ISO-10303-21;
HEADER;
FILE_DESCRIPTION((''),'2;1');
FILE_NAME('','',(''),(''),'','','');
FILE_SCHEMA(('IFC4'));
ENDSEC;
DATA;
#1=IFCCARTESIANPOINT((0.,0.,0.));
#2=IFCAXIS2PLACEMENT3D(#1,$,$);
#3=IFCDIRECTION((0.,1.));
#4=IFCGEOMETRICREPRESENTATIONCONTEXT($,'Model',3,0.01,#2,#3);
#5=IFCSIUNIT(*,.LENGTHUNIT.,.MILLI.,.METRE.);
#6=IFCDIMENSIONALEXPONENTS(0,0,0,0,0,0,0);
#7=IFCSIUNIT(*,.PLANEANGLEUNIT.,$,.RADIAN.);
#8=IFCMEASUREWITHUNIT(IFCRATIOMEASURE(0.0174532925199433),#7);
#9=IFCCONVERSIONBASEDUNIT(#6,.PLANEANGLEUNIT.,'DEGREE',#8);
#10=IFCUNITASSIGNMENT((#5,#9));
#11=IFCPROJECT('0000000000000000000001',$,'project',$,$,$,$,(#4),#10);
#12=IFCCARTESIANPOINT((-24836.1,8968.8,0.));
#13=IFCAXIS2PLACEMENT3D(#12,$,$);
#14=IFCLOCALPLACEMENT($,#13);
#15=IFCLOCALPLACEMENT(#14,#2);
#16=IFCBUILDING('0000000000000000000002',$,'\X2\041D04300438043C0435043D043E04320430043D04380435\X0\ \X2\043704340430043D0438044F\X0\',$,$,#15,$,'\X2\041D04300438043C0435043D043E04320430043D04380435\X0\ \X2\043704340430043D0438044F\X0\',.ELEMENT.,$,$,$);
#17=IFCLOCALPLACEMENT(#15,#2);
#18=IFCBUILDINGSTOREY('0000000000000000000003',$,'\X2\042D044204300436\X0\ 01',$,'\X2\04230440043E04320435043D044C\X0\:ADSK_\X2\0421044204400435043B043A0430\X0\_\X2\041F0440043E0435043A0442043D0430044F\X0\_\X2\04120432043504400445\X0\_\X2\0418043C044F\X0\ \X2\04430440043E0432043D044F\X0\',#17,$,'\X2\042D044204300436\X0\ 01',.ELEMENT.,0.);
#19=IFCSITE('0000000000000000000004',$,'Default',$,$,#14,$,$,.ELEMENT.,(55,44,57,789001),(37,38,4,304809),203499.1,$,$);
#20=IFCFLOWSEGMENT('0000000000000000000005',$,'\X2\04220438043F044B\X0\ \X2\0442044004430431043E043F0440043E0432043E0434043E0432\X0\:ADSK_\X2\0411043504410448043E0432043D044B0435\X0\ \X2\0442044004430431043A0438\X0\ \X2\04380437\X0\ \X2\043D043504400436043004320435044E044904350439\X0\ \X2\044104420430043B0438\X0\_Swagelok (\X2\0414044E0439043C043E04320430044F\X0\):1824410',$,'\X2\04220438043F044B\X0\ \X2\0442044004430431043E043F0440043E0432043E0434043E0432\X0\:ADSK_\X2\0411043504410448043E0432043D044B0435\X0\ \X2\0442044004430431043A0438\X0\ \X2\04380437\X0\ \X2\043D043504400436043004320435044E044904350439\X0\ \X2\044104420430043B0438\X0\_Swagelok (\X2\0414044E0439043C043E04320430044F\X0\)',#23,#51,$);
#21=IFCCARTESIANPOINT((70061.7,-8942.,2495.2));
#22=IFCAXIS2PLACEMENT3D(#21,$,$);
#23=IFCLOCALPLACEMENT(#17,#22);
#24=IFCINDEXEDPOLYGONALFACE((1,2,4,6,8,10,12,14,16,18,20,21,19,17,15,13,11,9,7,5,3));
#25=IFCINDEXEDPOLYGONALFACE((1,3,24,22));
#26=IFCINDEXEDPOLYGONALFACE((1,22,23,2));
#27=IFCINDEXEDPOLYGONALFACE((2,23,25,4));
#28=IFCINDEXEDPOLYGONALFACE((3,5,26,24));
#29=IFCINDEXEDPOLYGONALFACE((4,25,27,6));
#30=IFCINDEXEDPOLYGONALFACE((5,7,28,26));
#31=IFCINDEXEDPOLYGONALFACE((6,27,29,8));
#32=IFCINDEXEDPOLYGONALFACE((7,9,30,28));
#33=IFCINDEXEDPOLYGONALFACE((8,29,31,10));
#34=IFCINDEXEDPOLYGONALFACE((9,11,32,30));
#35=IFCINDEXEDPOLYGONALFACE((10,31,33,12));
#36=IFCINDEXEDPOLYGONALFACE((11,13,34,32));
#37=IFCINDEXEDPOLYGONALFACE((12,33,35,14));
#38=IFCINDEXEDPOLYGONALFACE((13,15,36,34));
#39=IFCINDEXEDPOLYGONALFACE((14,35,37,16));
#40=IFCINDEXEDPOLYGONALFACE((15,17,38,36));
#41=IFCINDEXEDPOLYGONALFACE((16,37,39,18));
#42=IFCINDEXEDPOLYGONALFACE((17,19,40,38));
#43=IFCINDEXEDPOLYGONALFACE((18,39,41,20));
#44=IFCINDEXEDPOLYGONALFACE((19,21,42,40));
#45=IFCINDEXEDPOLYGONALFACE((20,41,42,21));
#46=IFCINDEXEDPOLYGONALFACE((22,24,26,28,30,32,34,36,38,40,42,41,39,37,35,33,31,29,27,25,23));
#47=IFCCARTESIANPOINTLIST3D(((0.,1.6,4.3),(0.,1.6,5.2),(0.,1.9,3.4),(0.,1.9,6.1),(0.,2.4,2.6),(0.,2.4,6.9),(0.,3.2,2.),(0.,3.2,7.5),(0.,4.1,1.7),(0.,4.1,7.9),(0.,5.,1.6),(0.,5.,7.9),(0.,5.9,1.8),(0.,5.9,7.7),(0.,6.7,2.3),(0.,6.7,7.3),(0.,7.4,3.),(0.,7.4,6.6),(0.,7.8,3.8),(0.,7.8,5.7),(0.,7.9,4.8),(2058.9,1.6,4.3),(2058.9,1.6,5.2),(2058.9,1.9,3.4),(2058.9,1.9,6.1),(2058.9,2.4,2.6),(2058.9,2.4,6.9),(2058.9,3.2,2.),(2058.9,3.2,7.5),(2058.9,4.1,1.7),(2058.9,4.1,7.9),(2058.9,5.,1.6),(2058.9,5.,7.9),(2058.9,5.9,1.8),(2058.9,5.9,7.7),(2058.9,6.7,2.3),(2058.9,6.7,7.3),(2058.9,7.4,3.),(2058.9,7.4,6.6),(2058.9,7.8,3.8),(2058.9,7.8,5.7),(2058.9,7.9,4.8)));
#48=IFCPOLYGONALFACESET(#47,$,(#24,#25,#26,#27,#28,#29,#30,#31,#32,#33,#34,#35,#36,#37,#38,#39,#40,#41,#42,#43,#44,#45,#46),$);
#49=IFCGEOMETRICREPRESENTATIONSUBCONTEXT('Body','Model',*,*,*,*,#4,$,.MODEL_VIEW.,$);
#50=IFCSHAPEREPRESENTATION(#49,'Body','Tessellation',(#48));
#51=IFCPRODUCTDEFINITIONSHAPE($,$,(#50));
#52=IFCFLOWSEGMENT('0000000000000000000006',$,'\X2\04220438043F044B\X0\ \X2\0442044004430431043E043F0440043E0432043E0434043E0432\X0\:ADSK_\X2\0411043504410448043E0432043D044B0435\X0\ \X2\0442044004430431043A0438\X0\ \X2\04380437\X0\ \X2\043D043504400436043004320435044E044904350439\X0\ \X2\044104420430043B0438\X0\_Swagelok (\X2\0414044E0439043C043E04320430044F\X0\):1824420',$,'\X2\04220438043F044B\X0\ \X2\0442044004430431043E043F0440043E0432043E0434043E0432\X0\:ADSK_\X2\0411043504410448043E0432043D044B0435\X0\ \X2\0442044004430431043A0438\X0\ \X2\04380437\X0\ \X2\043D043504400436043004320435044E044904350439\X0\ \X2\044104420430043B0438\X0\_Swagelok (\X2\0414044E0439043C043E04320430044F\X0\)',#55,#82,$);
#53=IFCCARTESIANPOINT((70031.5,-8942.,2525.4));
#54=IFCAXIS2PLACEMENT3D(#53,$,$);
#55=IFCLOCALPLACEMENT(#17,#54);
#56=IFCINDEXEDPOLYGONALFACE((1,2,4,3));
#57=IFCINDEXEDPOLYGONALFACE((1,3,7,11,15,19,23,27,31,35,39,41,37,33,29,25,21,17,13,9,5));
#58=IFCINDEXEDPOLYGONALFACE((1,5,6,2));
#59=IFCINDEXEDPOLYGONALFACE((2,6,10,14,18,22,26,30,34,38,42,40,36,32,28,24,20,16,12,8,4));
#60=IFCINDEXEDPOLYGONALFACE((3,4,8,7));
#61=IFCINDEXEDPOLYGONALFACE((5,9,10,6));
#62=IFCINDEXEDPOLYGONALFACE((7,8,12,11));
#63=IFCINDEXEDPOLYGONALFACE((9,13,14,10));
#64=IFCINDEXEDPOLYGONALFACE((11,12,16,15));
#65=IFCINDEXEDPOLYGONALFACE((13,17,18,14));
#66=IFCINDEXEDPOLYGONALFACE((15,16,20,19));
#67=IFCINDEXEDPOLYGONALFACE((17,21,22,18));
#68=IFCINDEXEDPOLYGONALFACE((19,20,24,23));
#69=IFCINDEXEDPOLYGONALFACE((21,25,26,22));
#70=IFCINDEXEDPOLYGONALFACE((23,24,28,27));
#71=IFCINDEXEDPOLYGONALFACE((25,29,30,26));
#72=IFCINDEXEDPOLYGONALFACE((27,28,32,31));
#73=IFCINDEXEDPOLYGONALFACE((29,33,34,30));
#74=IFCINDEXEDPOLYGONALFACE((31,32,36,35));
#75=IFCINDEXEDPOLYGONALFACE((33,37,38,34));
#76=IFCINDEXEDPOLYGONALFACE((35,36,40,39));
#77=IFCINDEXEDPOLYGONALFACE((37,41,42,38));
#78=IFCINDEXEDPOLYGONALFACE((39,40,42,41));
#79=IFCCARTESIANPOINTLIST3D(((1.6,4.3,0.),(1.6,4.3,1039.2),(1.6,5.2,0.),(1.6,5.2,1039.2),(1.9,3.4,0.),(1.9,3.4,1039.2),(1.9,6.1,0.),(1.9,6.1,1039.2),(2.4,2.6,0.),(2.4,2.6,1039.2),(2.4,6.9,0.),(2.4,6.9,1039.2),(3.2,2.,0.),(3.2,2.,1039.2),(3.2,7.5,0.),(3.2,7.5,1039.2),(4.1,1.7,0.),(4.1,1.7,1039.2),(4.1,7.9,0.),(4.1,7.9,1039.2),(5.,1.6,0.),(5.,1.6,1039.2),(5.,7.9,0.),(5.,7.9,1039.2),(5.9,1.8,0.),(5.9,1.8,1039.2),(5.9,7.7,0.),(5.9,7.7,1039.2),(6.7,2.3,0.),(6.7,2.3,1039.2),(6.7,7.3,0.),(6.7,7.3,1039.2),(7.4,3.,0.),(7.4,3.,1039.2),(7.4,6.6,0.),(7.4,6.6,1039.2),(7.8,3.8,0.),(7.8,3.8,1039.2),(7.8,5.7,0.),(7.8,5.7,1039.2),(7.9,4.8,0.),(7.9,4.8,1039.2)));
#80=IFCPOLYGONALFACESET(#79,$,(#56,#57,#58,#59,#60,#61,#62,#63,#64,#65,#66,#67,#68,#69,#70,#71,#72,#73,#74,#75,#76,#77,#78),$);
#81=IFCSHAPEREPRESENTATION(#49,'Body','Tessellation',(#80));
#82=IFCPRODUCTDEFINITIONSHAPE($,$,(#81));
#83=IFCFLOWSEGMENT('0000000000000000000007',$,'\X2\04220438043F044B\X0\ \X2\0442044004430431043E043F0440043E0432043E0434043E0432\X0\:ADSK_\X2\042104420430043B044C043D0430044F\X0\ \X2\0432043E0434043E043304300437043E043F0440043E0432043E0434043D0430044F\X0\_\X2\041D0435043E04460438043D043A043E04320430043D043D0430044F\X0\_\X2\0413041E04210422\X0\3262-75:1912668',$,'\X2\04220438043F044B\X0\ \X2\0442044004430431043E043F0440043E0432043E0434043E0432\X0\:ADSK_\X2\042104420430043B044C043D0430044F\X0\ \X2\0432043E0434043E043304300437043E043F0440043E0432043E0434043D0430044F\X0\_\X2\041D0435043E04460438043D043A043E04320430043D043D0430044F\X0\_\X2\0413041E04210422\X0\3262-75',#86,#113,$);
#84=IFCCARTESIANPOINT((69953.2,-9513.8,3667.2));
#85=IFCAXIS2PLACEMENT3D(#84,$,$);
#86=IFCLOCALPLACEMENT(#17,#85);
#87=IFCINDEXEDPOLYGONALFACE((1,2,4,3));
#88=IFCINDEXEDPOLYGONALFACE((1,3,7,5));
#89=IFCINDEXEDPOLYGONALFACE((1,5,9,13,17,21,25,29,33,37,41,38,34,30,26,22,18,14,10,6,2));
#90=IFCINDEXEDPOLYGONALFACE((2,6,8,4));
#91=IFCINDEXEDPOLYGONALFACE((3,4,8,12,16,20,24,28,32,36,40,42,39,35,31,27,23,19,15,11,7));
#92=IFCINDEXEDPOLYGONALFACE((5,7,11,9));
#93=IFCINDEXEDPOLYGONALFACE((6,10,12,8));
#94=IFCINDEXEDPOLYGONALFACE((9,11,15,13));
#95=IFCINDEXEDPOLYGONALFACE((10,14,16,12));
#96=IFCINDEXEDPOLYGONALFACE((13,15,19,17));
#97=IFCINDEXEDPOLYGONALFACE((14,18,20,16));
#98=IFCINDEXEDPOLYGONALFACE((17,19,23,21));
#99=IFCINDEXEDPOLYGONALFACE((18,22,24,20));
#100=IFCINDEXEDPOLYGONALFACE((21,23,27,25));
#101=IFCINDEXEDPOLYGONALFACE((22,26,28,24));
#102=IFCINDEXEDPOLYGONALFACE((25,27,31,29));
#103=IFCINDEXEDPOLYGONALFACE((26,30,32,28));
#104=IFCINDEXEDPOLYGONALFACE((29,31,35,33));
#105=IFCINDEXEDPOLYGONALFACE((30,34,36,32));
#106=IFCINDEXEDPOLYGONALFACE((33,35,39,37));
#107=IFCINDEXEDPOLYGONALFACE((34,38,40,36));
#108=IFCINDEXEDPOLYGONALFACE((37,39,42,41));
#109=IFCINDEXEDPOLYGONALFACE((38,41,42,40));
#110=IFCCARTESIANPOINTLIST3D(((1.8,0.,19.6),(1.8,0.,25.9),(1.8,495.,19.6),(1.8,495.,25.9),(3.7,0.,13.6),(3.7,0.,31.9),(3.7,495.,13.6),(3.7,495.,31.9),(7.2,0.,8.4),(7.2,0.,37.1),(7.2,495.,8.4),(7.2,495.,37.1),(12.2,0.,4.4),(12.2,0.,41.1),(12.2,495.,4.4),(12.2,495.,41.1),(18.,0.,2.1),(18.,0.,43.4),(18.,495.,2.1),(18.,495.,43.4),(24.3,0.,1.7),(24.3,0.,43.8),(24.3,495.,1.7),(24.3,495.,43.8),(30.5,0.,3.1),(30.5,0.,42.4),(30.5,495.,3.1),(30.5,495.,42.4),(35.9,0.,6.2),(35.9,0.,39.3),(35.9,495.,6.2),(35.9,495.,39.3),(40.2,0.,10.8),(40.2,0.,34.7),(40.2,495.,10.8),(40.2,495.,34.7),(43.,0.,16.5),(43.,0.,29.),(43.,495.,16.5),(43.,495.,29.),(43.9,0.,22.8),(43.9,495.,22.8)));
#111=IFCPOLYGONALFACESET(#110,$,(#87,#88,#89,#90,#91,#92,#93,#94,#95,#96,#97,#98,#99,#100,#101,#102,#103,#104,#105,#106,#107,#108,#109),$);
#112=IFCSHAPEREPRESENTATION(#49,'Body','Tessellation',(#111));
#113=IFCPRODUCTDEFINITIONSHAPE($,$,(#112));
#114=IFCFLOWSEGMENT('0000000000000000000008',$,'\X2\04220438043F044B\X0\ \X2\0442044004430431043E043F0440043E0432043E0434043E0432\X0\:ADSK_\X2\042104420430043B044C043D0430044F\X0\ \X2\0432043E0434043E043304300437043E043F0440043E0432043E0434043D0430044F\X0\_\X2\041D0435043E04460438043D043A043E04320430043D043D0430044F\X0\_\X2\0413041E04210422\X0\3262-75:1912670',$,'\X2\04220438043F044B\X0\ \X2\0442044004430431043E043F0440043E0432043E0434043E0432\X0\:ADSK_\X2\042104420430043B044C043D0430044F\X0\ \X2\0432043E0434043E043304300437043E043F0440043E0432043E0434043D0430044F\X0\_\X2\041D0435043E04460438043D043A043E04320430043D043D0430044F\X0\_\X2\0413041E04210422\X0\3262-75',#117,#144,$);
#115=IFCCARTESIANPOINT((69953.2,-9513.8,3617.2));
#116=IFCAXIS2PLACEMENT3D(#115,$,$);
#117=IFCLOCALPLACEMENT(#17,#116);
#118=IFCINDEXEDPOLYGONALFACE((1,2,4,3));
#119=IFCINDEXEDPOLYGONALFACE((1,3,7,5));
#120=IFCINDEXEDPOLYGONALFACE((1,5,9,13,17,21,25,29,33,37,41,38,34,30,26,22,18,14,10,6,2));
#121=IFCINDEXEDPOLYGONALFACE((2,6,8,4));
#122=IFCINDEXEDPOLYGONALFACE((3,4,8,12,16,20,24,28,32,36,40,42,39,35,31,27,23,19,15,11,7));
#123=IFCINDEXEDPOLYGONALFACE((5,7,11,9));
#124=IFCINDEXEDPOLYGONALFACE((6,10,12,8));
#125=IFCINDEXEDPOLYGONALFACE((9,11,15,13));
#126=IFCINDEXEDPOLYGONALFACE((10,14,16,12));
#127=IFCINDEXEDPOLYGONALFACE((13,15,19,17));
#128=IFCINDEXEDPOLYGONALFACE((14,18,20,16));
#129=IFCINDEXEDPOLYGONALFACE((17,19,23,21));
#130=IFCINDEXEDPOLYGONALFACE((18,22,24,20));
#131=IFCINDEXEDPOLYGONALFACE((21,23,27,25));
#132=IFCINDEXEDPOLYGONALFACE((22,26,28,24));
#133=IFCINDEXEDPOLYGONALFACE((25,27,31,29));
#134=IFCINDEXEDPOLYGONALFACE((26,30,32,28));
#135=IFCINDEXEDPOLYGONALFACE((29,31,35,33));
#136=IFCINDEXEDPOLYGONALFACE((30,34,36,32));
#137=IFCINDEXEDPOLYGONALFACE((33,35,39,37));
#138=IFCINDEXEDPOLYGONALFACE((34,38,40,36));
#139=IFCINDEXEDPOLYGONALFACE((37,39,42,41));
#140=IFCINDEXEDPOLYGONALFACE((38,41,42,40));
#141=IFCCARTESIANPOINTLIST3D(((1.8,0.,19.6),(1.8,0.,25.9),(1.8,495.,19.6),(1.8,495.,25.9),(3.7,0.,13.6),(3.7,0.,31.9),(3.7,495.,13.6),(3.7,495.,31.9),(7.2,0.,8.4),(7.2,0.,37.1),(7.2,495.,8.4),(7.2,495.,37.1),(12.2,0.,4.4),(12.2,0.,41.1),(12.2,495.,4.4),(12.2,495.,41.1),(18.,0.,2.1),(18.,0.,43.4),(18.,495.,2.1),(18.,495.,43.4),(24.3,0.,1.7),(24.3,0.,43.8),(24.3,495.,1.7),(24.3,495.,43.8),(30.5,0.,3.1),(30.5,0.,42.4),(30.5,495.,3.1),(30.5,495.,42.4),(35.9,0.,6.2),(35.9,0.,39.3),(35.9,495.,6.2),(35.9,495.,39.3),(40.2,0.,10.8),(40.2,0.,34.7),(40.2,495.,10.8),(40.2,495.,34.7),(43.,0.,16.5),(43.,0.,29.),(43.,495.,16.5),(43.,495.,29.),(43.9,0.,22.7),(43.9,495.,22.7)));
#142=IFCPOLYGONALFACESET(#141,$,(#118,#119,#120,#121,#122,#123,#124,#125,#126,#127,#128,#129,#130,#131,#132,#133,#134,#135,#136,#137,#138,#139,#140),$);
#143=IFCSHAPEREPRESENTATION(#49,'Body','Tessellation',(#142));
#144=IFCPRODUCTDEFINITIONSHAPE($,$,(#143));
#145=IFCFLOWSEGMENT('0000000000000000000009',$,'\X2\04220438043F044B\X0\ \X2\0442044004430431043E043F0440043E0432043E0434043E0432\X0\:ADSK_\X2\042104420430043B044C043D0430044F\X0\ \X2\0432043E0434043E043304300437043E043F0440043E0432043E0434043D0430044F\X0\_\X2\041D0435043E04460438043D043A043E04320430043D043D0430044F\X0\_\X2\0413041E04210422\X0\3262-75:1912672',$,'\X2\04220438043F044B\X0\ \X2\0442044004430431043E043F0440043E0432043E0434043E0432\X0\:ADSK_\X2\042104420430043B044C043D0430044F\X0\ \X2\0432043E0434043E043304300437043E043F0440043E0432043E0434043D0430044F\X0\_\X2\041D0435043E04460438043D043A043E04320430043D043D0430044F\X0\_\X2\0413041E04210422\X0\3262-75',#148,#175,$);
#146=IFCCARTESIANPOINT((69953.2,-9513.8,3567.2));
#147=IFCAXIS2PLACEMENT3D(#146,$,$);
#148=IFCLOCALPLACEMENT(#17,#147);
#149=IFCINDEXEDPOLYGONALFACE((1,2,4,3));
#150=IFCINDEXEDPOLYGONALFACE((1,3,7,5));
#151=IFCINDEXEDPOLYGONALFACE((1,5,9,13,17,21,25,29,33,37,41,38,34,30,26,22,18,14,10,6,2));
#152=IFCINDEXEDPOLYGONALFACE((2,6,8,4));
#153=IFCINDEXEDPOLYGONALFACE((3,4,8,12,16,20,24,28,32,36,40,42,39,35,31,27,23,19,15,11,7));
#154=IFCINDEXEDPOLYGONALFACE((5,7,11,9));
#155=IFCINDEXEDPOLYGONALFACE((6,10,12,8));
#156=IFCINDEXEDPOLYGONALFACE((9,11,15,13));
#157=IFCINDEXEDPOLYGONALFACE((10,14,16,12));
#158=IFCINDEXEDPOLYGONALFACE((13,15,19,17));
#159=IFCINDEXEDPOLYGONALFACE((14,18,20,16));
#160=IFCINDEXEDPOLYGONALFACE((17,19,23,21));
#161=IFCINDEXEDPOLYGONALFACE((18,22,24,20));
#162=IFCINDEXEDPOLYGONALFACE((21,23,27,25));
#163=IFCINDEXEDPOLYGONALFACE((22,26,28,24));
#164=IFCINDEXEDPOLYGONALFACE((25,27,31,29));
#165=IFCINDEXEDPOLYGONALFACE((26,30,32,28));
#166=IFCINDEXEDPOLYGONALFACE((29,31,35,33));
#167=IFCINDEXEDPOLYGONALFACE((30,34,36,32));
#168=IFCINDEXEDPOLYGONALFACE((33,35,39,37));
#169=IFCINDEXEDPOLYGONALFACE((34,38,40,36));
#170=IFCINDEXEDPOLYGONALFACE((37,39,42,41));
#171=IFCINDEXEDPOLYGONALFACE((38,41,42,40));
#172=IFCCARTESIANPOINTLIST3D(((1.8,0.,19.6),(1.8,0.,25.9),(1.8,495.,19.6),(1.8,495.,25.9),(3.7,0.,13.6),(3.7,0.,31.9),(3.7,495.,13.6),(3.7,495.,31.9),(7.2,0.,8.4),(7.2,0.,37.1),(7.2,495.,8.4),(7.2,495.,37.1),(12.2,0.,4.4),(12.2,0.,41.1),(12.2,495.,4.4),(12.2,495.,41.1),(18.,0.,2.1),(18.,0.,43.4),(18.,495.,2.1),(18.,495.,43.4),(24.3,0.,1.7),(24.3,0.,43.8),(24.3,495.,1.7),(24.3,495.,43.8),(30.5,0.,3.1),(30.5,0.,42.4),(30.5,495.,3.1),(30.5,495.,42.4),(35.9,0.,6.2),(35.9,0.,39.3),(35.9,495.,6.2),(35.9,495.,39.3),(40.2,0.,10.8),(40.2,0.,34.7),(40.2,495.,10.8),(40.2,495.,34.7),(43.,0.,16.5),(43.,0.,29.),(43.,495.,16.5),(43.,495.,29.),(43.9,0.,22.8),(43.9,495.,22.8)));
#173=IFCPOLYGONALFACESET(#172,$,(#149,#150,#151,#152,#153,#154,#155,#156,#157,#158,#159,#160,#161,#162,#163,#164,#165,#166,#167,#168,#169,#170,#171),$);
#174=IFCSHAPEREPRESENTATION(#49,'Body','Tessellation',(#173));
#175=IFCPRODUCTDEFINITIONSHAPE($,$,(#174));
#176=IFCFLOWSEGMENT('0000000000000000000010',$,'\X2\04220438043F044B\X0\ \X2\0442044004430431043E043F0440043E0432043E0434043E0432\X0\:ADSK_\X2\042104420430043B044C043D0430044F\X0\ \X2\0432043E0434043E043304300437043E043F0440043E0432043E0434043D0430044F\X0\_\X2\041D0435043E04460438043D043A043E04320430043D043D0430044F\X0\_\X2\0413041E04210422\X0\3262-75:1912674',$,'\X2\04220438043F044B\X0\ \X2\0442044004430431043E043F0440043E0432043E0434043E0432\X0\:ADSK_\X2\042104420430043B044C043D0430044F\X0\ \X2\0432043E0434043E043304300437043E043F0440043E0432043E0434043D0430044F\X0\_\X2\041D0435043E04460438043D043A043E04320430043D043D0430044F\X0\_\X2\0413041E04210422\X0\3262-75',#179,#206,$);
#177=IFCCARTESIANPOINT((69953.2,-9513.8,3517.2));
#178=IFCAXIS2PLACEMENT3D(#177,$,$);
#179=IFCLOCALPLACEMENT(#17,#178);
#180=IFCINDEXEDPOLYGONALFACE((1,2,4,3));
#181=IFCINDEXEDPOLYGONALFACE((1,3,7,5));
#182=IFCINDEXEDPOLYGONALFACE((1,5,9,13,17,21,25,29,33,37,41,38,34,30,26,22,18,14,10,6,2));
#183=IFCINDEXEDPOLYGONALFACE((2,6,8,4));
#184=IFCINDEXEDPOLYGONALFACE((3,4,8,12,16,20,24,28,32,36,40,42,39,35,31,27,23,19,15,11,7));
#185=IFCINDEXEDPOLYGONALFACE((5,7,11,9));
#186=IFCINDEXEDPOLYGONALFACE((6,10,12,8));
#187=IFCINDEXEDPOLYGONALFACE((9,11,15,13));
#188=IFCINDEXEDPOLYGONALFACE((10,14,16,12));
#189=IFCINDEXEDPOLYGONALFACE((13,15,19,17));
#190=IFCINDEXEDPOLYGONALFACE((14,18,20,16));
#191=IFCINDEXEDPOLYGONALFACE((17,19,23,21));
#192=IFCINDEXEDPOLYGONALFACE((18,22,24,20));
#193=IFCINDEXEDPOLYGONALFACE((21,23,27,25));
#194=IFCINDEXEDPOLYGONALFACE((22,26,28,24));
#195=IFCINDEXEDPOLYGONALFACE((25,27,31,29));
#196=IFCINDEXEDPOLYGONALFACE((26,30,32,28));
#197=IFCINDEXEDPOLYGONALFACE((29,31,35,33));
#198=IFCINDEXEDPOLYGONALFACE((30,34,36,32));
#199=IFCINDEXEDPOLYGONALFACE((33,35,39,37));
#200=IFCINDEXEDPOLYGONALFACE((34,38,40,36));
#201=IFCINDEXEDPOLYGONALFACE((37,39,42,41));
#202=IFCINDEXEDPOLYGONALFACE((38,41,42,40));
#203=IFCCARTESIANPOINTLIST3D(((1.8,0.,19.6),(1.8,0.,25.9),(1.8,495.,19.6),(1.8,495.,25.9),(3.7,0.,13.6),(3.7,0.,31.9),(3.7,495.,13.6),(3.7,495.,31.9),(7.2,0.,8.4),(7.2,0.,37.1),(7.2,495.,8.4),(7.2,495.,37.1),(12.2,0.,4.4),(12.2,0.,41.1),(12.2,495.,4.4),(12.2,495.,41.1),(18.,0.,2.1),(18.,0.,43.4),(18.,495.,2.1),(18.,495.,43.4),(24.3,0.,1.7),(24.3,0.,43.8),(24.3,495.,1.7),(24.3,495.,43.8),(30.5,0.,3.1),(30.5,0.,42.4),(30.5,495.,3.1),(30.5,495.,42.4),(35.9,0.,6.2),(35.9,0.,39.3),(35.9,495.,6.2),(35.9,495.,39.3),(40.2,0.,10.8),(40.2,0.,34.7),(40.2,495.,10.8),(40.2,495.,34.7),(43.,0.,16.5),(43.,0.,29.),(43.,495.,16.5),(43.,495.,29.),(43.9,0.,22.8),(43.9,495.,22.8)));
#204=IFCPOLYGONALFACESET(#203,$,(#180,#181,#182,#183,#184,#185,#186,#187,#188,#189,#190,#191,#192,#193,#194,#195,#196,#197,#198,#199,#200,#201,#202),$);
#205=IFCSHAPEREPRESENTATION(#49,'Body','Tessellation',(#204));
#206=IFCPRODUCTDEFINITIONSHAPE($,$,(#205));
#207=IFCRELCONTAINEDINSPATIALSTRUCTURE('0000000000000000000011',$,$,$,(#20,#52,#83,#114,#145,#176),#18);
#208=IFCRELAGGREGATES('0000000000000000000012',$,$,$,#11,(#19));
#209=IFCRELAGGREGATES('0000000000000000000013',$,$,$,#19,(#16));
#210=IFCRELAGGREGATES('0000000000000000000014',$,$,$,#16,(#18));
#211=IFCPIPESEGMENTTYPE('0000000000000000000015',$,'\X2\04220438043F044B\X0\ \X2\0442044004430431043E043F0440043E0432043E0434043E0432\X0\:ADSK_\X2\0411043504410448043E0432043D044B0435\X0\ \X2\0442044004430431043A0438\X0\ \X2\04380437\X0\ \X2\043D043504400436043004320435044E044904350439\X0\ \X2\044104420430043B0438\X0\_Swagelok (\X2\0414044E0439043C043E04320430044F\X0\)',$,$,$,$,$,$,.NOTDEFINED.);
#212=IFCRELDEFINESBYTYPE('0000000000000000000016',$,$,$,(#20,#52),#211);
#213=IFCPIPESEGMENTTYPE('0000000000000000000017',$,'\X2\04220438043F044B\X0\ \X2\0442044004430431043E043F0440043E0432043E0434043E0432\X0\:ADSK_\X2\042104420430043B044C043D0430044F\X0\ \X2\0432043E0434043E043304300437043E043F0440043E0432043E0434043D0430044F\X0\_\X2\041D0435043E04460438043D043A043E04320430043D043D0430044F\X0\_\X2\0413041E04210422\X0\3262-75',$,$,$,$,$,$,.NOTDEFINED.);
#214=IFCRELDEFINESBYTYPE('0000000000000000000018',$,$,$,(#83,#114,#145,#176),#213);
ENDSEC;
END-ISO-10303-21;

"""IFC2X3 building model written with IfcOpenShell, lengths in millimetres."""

from ifc_helpers import new_model, entity, si_unit, converted_unit, direction, frame, origin, origin_2d_with_axis, place, context, subcontext, project, spatial, circle, extrude, type_object, element, save


model = new_model("IFC2X3")

# Units and contexts
model_context = context("Model", 3, precision=0.01, world=origin(), true_north=direction((0.0, 1.0)))
body_context = subcontext(model_context, "Body", "Model", "MODEL_VIEW")
ifc_project = project(units=[si_unit("LENGTHUNIT", "METRE", prefix="MILLI"), converted_unit("PLANEANGLEUNIT", "DEGREE", entity("IfcRatioMeasure", 0.0174532925199433), si_unit("PLANEANGLEUNIT", "RADIAN"), dimensions=[0, 0, 0, 0, 0, 0, 0])], contexts=[model_context])

# Site, building, storey
site_placement = place(None, frame((-24836.1, 8968.8, 0.0)))
site = spatial("IfcSite", under=ifc_project, at=site_placement, Name="Default", CompositionType="ELEMENT", RefLatitude=(55, 44, 57, 789001), RefLongitude=(37, 38, 4, 304809), RefElevation=203499.1)
building_placement = place(site_placement, origin())
building = spatial("IfcBuilding", under=site, at=building_placement, Name="Наименование здания", LongName="Наименование здания", CompositionType="ELEMENT")
storey_placement = place(building_placement, origin())
storey = spatial("IfcBuildingStorey", under=building, at=storey_placement, Name="Этаж 01", ObjectType="Уровень:ADSK_Стрелка_Проектная_Вверх_Имя уровня", LongName="Этаж 01", CompositionType="ELEMENT", Elevation=0.0)

# Flow segments
pipe_segment_type_1 = type_object("IfcPipeSegmentType", Name="Типы трубопроводов:ADSK_Бесшовные трубки из нержавеющей стали_Swagelok (Дюймовая)", PredefinedType="NOTDEFINED")
flow_segment_1_placement = place(storey_placement, frame((70061.7, -8942.0, 2495.2)))
element("IfcFlowSegment", 1, at=flow_segment_1_placement, inside=storey, type_object=pipe_segment_type_1, Name="Типы трубопроводов:ADSK_Бесшовные трубки из нержавеющей стали_Swagelok (Дюймовая):1824410", ObjectType="Типы трубопроводов:ADSK_Бесшовные трубки из нержавеющей стали_Swagelok (Дюймовая)", context=body_context, shape_type="SweptSolid", body=[
    extrude(circle(Radius=3.2, at=origin_2d_with_axis()), frame((0.0, 4.8, 4.8), z_axis=(1.0, 0.0, 0.0), x_axis=(0.0, 1.0, 0.0)), (0.0, 0.0, 1.0), 2058.9),
])
flow_segment_2_placement = place(storey_placement, frame((70031.5, -8942.0, 2525.4)))
element("IfcFlowSegment", 2, at=flow_segment_2_placement, inside=storey, type_object=pipe_segment_type_1, Name="Типы трубопроводов:ADSK_Бесшовные трубки из нержавеющей стали_Swagelok (Дюймовая):1824420", ObjectType="Типы трубопроводов:ADSK_Бесшовные трубки из нержавеющей стали_Swagelok (Дюймовая)", context=body_context, shape_type="SweptSolid", body=[
    extrude(circle(Radius=3.2, at=origin_2d_with_axis()), frame((4.8, 4.8, 0.0)), (0.0, 0.0, 1.0), 1039.2),
])
pipe_segment_type_2 = type_object("IfcPipeSegmentType", Name="Типы трубопроводов:ADSK_Стальная водогазопроводная_Неоцинкованная_ГОСТ3262-75", PredefinedType="NOTDEFINED")
flow_segment_3_placement = place(storey_placement, frame((69953.2, -9513.8, 3667.2)))
element("IfcFlowSegment", 3, at=flow_segment_3_placement, inside=storey, type_object=pipe_segment_type_2, Name="Типы трубопроводов:ADSK_Стальная водогазопроводная_Неоцинкованная_ГОСТ3262-75:1912668", ObjectType="Типы трубопроводов:ADSK_Стальная водогазопроводная_Неоцинкованная_ГОСТ3262-75", context=body_context, shape_type="SweptSolid", body=[
    extrude(circle(Radius=21.1, at=origin_2d_with_axis()), frame((22.8, 0.0, 22.8), z_axis=(0.0, 1.0, 0.0), x_axis=(1.0, 0.0, 0.0)), (0.0, 0.0, 1.0), 495.0),
])
flow_segment_4_placement = place(storey_placement, frame((69953.2, -9513.8, 3617.2)))
element("IfcFlowSegment", 4, at=flow_segment_4_placement, inside=storey, type_object=pipe_segment_type_2, Name="Типы трубопроводов:ADSK_Стальная водогазопроводная_Неоцинкованная_ГОСТ3262-75:1912670", ObjectType="Типы трубопроводов:ADSK_Стальная водогазопроводная_Неоцинкованная_ГОСТ3262-75", context=body_context, shape_type="SweptSolid", body=[
    extrude(circle(Radius=21.1, at=origin_2d_with_axis()), frame((22.8, 0.0, 22.8), z_axis=(0.0, 1.0, 0.0), x_axis=(1.0, 0.0, 0.0)), (0.0, 0.0, 1.0), 495.0),
])
flow_segment_5_placement = place(storey_placement, frame((69953.2, -9513.8, 3567.2)))
element("IfcFlowSegment", 5, at=flow_segment_5_placement, inside=storey, type_object=pipe_segment_type_2, Name="Типы трубопроводов:ADSK_Стальная водогазопроводная_Неоцинкованная_ГОСТ3262-75:1912672", ObjectType="Типы трубопроводов:ADSK_Стальная водогазопроводная_Неоцинкованная_ГОСТ3262-75", context=body_context, shape_type="SweptSolid", body=[
    extrude(circle(Radius=21.1, at=origin_2d_with_axis()), frame((22.8, 0.0, 22.8), z_axis=(0.0, 1.0, 0.0), x_axis=(1.0, 0.0, 0.0)), (0.0, 0.0, 1.0), 495.0),
])
flow_segment_6_placement = place(storey_placement, frame((69953.2, -9513.8, 3517.2)))
element("IfcFlowSegment", 6, at=flow_segment_6_placement, inside=storey, type_object=pipe_segment_type_2, Name="Типы трубопроводов:ADSK_Стальная водогазопроводная_Неоцинкованная_ГОСТ3262-75:1912674", ObjectType="Типы трубопроводов:ADSK_Стальная водогазопроводная_Неоцинкованная_ГОСТ3262-75", context=body_context, shape_type="SweptSolid", body=[
    extrude(circle(Radius=21.1, at=origin_2d_with_axis()), frame((22.8, 0.0, 22.8), z_axis=(0.0, 1.0, 0.0), x_axis=(1.0, 0.0, 0.0)), (0.0, 0.0, 1.0), 495.0),
])

save(model, "model.ifc")
